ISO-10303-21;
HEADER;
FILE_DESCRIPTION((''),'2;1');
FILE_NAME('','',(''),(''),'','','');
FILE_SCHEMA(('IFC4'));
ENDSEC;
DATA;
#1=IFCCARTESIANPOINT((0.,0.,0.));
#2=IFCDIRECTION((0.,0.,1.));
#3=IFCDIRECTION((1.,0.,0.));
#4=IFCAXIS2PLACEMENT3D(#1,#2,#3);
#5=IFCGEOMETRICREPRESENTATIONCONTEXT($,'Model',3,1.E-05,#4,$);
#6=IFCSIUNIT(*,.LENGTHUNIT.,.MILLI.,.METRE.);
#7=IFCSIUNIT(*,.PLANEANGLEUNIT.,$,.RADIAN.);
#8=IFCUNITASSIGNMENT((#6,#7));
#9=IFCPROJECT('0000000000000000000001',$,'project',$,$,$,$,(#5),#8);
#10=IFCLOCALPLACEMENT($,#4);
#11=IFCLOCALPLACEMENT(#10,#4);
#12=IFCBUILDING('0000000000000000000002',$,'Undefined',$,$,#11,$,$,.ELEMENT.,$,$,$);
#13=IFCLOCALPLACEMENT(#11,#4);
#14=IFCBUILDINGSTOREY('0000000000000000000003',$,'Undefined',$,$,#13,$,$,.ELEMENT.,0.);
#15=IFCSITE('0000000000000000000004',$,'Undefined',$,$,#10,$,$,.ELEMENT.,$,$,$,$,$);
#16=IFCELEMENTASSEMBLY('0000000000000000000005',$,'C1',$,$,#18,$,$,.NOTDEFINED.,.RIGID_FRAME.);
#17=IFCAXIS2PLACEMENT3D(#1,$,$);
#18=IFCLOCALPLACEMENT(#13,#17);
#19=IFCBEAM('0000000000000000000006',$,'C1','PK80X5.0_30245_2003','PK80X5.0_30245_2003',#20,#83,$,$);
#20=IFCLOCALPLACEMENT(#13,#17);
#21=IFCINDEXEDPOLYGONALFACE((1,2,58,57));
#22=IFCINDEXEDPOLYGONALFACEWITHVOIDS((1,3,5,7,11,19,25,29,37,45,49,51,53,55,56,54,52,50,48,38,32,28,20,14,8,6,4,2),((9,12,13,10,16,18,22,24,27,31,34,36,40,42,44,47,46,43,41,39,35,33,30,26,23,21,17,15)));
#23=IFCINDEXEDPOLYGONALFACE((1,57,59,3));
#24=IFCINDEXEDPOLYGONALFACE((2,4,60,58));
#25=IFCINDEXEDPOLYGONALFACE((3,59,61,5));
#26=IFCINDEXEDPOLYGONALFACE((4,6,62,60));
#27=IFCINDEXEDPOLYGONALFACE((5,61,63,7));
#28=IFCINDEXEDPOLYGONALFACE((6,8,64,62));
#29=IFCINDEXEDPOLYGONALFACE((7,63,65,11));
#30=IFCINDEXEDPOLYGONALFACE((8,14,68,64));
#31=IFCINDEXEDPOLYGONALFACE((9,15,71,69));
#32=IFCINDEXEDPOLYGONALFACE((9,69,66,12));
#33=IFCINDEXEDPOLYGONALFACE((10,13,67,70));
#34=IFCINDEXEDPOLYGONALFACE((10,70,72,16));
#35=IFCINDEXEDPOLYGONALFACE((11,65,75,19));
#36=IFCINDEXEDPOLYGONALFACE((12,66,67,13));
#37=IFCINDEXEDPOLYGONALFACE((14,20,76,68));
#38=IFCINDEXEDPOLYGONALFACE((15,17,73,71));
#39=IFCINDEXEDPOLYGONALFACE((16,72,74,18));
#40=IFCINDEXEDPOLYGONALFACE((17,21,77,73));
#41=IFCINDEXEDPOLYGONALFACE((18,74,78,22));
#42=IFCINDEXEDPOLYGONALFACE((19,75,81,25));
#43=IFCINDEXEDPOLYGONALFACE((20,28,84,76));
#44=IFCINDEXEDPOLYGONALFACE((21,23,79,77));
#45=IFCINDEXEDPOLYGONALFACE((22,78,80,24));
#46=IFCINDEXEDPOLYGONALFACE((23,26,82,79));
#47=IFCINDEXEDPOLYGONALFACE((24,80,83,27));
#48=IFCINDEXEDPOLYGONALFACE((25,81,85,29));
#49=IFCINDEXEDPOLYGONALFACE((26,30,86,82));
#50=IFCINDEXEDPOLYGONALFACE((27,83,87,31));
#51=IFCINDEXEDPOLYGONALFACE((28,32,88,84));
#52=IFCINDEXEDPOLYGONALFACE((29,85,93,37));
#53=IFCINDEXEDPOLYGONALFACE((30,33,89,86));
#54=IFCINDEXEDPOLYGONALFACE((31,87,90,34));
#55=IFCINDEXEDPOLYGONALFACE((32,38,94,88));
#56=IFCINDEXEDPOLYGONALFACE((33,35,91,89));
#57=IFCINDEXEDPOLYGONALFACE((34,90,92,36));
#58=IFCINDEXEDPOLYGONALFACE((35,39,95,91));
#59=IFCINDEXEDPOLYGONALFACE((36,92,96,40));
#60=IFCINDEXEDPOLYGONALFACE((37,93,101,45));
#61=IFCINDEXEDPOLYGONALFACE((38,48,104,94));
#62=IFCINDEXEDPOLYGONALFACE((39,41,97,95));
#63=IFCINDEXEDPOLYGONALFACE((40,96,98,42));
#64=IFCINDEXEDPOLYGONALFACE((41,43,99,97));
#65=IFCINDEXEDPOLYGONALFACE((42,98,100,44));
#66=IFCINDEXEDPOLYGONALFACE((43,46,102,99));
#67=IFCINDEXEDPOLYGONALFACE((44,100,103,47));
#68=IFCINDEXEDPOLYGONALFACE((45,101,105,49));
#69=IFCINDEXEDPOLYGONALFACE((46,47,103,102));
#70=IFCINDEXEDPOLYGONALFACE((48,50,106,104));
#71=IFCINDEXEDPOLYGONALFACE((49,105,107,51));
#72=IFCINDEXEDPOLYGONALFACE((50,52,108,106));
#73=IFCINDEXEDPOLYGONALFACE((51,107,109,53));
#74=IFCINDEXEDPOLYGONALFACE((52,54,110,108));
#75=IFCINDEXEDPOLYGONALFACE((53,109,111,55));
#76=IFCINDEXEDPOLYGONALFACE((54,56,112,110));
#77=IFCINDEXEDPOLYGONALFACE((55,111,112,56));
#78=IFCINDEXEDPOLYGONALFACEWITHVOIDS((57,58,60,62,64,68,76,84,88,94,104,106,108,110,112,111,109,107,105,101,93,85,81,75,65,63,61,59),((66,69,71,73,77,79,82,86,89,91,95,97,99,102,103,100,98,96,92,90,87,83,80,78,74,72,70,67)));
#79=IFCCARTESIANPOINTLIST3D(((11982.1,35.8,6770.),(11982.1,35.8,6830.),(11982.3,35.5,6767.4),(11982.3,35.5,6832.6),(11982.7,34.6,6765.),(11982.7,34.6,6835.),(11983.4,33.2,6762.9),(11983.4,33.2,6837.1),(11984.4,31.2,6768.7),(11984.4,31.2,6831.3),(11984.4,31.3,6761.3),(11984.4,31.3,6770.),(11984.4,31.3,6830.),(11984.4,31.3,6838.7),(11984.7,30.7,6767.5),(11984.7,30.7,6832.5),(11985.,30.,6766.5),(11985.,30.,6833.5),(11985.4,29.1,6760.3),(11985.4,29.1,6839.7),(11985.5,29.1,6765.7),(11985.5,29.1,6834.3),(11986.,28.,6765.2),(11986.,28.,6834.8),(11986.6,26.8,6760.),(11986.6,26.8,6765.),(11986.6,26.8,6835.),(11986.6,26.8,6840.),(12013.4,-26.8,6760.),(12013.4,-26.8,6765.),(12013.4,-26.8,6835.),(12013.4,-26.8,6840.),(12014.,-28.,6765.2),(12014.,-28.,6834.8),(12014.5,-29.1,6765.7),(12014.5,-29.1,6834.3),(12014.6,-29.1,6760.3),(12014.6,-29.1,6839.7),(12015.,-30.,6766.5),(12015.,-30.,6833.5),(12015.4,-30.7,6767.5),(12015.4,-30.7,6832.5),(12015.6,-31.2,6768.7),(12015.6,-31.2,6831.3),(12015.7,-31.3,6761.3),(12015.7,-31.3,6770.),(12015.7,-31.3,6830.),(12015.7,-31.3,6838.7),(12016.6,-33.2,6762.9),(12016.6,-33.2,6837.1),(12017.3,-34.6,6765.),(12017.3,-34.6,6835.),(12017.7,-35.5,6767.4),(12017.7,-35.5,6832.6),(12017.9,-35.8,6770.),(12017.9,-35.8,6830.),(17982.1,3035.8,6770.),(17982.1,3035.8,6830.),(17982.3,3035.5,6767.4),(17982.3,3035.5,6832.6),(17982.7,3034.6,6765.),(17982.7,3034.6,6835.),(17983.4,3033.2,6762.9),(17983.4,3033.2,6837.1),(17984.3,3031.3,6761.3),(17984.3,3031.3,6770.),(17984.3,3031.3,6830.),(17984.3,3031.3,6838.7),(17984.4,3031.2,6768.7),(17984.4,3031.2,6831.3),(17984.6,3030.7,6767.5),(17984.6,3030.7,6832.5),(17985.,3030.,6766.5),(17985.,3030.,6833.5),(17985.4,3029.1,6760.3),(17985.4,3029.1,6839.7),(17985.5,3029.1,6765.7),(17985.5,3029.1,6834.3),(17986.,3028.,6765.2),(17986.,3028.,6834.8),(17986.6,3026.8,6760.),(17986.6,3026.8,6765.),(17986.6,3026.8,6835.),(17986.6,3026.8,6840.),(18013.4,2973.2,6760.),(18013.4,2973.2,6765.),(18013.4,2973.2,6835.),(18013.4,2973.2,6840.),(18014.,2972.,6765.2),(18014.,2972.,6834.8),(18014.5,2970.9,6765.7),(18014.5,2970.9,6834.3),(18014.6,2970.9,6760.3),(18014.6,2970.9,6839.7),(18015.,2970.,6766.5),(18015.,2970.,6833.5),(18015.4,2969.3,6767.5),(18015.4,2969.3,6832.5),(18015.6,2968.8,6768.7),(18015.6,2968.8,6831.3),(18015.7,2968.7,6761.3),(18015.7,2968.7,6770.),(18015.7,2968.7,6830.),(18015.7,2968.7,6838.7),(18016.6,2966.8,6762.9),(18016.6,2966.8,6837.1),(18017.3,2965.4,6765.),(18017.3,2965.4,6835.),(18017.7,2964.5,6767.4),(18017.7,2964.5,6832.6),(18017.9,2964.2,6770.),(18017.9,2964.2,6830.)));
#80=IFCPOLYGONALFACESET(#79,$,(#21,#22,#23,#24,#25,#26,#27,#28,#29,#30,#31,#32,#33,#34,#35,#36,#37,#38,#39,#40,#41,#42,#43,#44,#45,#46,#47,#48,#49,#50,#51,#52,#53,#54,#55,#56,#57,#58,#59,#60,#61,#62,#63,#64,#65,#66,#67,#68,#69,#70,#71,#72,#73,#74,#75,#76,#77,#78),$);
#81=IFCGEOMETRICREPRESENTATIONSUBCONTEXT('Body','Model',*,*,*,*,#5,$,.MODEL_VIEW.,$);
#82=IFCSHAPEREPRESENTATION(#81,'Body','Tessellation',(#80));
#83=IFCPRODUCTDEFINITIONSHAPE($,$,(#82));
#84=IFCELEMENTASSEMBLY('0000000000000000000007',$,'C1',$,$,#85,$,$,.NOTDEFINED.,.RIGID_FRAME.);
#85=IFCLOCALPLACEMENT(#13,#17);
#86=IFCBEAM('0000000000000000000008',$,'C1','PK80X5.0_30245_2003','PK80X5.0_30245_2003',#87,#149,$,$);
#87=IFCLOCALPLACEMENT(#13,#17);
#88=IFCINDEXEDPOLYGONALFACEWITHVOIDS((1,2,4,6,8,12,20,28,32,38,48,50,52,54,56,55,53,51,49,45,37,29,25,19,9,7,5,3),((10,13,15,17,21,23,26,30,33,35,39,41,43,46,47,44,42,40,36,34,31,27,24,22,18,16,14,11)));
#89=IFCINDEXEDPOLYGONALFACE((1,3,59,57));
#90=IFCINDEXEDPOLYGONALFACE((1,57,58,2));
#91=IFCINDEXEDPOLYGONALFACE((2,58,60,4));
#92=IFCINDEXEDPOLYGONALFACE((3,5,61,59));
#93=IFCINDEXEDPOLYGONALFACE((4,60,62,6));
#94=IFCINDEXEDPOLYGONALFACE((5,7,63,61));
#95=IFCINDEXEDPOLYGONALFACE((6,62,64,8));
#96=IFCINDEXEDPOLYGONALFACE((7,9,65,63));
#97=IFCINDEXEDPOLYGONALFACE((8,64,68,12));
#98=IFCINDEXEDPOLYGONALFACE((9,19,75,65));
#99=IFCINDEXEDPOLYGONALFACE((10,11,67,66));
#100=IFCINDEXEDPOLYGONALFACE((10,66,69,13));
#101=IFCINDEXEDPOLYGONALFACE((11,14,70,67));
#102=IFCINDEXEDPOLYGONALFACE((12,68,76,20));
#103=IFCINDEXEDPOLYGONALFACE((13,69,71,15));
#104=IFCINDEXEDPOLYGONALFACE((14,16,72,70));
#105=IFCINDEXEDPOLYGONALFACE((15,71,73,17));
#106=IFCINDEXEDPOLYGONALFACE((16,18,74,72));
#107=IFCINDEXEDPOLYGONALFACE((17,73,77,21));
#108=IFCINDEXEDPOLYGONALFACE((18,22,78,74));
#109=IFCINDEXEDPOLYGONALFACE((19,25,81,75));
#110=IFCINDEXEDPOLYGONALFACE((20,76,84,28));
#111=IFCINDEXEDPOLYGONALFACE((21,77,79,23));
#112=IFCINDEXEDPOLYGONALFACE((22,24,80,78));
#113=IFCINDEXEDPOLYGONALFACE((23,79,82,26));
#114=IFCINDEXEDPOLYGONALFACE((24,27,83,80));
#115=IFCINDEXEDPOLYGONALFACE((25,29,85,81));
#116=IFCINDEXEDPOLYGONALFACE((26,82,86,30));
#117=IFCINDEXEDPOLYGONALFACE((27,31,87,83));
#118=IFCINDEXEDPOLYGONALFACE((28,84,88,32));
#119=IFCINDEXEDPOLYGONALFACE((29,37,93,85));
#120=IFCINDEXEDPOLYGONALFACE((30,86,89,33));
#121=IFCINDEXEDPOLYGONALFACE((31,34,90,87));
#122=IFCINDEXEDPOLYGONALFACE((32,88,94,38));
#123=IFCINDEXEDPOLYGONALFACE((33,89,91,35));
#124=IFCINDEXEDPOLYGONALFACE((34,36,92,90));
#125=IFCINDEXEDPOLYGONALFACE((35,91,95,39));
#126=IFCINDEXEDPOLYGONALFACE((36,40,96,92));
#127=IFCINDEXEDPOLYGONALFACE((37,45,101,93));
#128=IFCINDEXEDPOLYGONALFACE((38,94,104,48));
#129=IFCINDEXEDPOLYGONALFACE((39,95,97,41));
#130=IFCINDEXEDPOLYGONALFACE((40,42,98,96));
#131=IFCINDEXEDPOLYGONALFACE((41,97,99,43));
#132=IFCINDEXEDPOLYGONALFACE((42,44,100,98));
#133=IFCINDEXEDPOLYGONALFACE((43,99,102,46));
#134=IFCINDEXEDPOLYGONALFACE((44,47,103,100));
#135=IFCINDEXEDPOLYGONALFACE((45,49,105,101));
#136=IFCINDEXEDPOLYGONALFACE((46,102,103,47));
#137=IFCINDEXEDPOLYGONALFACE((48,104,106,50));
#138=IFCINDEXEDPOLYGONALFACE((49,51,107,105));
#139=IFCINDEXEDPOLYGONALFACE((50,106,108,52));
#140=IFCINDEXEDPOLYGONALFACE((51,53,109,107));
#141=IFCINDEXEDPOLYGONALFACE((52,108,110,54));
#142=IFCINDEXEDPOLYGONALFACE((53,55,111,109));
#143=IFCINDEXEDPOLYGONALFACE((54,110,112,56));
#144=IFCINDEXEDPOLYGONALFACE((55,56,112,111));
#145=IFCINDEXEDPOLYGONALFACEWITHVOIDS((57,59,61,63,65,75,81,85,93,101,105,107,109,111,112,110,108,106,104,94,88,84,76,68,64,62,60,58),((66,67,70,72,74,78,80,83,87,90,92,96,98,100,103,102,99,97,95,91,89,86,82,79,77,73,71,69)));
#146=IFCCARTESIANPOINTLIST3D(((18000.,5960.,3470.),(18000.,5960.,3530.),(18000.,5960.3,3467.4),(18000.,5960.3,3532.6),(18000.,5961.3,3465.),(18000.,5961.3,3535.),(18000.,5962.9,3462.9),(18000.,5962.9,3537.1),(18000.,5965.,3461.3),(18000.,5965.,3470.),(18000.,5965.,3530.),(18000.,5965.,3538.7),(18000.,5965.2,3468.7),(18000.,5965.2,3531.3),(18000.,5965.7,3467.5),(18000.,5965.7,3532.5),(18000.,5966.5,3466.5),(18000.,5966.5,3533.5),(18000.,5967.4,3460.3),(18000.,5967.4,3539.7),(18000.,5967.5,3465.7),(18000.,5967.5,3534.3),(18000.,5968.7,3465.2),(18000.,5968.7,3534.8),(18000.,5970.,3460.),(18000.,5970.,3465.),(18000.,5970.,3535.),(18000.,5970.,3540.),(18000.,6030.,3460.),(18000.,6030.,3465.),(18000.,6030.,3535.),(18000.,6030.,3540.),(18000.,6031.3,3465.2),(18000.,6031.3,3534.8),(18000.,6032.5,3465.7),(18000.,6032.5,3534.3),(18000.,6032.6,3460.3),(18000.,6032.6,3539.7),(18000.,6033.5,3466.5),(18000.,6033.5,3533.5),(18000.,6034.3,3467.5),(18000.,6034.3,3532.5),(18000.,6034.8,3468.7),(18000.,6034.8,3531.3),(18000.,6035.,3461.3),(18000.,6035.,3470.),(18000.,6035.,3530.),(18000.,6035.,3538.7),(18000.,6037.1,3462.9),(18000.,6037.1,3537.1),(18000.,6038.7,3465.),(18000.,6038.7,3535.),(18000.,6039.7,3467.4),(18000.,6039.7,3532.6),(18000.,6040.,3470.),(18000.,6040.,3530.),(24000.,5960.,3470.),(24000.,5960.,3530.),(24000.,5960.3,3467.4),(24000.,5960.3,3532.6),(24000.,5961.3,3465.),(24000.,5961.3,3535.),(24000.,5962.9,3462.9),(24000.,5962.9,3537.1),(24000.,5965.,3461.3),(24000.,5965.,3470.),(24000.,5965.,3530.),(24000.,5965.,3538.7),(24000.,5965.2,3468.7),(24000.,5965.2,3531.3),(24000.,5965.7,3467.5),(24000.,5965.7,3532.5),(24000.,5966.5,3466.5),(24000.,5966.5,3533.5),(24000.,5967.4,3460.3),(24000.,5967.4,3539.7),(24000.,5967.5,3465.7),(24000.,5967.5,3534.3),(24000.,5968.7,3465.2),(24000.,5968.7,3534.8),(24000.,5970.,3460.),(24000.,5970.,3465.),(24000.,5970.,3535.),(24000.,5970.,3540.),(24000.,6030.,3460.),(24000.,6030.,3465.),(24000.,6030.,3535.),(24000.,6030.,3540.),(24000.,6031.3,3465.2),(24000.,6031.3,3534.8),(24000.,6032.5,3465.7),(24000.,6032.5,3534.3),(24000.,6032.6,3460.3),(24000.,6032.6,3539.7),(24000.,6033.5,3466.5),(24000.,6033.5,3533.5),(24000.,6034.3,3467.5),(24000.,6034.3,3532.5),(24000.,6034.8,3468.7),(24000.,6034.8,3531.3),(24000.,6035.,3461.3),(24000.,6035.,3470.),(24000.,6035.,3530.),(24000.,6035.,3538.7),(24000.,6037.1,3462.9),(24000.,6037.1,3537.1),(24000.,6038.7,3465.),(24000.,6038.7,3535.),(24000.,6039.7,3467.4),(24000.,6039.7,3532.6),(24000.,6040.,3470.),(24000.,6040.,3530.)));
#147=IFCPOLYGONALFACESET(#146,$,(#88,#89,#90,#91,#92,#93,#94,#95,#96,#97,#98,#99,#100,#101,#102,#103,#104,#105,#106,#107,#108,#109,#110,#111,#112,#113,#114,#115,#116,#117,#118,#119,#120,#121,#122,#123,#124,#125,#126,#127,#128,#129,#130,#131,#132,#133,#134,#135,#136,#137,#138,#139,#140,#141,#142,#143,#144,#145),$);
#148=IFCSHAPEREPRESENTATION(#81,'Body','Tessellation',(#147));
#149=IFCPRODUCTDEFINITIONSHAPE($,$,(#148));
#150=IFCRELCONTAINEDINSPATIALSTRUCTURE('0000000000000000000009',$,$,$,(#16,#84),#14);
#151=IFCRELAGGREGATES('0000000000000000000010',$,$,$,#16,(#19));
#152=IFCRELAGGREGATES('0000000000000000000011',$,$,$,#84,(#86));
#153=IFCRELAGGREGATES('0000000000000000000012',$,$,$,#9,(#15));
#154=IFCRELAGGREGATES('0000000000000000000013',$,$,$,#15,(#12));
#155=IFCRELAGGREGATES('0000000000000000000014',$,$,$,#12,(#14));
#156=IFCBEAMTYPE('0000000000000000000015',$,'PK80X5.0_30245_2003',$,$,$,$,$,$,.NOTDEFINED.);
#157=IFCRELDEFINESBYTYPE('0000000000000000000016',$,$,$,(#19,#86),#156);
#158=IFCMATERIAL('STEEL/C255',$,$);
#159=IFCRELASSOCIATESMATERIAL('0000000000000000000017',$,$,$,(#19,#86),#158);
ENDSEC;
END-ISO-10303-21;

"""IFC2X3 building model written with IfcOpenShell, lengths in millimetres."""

from ifc_helpers import new_model, si_unit, frame, origin_with_axes, origin_2d_with_axis, place, context, subcontext, project, spatial, hollow_rectangle, extrude, material, type_object, element, aggregate, save


model = new_model("IFC2X3")

# Units and contexts
model_context = context("Model", 3, precision=1e-05, world=origin_with_axes())
body_context = subcontext(model_context, "Body", "Model", "MODEL_VIEW")
ifc_project = project(units=[si_unit("LENGTHUNIT", "METRE", prefix="MILLI"), si_unit("PLANEANGLEUNIT", "RADIAN")], contexts=[model_context])

# Site, building, storey
site_placement = place(None, origin_with_axes())
site = spatial("IfcSite", under=ifc_project, at=site_placement, Name="Undefined", CompositionType="ELEMENT")
building_placement = place(site_placement, origin_with_axes())
building = spatial("IfcBuilding", under=site, at=building_placement, Name="Undefined", CompositionType="ELEMENT")
storey_placement = place(building_placement, origin_with_axes())
storey = spatial("IfcBuildingStorey", under=building, at=storey_placement, Name="Undefined", CompositionType="ELEMENT", Elevation=0.0)

# Element assemblies, beams
ifc_material_1 = material(Name="STEEL/C255")
beam_type_1 = type_object("IfcBeamType", Name="PK80X5.0_30245_2003", PredefinedType="NOTDEFINED")
assembly_1_placement = place(storey_placement, origin_with_axes())
assembly_1 = element("IfcElementAssembly", 1, at=assembly_1_placement, inside=storey, Name="C1", AssemblyPlace="NOTDEFINED", PredefinedType="RIGID_FRAME")
beam_1_placement = place(assembly_1_placement, frame((12000.0, 0.0, 6800.0), z_axis=(0.0, 0.0, -1.0), x_axis=(0.894427, 0.447214, 0.0)))
beam_1 = element("IfcBeam", 2, at=beam_1_placement, type_object=beam_type_1, material=ifc_material_1, Name="C1", Description="PK80X5.0_30245_2003", ObjectType="PK80X5.0_30245_2003", context=body_context, shape_type="SweptSolid", body=[
    extrude(hollow_rectangle(XDim=80.0, YDim=80.0, WallThickness=5.0, InnerFilletRadius=5.0, OuterFilletRadius=10.0, at=origin_2d_with_axis()), frame((6708.2, 0.0, 0.0), z_axis=(-1.0, 0.0, 0.0), x_axis=(0.0, -1.0, 0.0)), (0.0, 0.0, 1.0), 6708.2),
])
aggregate(assembly_1, [beam_1])
assembly_2_placement = place(storey_placement, origin_with_axes())
assembly_2 = element("IfcElementAssembly", 3, at=assembly_2_placement, inside=storey, Name="C1", AssemblyPlace="NOTDEFINED", PredefinedType="RIGID_FRAME")
beam_2_placement = place(assembly_2_placement, frame((18000.0, 6000.0, 3500.0), z_axis=(0.0, 0.0, -1.0), x_axis=(1.0, 0.0, 0.0)))
beam_2 = element("IfcBeam", 4, at=beam_2_placement, type_object=beam_type_1, material=ifc_material_1, Name="C1", Description="PK80X5.0_30245_2003", ObjectType="PK80X5.0_30245_2003", context=body_context, shape_type="SweptSolid", body=[
    extrude(hollow_rectangle(XDim=80.0, YDim=80.0, WallThickness=5.0, InnerFilletRadius=5.0, OuterFilletRadius=10.0, at=origin_2d_with_axis()), frame((6000.0, 0.0, 0.0), z_axis=(-1.0, 0.0, 0.0), x_axis=(0.0, -1.0, 0.0)), (0.0, 0.0, 1.0), 6000.0),
])
aggregate(assembly_2, [beam_2])

save(model, "model.ifc")
